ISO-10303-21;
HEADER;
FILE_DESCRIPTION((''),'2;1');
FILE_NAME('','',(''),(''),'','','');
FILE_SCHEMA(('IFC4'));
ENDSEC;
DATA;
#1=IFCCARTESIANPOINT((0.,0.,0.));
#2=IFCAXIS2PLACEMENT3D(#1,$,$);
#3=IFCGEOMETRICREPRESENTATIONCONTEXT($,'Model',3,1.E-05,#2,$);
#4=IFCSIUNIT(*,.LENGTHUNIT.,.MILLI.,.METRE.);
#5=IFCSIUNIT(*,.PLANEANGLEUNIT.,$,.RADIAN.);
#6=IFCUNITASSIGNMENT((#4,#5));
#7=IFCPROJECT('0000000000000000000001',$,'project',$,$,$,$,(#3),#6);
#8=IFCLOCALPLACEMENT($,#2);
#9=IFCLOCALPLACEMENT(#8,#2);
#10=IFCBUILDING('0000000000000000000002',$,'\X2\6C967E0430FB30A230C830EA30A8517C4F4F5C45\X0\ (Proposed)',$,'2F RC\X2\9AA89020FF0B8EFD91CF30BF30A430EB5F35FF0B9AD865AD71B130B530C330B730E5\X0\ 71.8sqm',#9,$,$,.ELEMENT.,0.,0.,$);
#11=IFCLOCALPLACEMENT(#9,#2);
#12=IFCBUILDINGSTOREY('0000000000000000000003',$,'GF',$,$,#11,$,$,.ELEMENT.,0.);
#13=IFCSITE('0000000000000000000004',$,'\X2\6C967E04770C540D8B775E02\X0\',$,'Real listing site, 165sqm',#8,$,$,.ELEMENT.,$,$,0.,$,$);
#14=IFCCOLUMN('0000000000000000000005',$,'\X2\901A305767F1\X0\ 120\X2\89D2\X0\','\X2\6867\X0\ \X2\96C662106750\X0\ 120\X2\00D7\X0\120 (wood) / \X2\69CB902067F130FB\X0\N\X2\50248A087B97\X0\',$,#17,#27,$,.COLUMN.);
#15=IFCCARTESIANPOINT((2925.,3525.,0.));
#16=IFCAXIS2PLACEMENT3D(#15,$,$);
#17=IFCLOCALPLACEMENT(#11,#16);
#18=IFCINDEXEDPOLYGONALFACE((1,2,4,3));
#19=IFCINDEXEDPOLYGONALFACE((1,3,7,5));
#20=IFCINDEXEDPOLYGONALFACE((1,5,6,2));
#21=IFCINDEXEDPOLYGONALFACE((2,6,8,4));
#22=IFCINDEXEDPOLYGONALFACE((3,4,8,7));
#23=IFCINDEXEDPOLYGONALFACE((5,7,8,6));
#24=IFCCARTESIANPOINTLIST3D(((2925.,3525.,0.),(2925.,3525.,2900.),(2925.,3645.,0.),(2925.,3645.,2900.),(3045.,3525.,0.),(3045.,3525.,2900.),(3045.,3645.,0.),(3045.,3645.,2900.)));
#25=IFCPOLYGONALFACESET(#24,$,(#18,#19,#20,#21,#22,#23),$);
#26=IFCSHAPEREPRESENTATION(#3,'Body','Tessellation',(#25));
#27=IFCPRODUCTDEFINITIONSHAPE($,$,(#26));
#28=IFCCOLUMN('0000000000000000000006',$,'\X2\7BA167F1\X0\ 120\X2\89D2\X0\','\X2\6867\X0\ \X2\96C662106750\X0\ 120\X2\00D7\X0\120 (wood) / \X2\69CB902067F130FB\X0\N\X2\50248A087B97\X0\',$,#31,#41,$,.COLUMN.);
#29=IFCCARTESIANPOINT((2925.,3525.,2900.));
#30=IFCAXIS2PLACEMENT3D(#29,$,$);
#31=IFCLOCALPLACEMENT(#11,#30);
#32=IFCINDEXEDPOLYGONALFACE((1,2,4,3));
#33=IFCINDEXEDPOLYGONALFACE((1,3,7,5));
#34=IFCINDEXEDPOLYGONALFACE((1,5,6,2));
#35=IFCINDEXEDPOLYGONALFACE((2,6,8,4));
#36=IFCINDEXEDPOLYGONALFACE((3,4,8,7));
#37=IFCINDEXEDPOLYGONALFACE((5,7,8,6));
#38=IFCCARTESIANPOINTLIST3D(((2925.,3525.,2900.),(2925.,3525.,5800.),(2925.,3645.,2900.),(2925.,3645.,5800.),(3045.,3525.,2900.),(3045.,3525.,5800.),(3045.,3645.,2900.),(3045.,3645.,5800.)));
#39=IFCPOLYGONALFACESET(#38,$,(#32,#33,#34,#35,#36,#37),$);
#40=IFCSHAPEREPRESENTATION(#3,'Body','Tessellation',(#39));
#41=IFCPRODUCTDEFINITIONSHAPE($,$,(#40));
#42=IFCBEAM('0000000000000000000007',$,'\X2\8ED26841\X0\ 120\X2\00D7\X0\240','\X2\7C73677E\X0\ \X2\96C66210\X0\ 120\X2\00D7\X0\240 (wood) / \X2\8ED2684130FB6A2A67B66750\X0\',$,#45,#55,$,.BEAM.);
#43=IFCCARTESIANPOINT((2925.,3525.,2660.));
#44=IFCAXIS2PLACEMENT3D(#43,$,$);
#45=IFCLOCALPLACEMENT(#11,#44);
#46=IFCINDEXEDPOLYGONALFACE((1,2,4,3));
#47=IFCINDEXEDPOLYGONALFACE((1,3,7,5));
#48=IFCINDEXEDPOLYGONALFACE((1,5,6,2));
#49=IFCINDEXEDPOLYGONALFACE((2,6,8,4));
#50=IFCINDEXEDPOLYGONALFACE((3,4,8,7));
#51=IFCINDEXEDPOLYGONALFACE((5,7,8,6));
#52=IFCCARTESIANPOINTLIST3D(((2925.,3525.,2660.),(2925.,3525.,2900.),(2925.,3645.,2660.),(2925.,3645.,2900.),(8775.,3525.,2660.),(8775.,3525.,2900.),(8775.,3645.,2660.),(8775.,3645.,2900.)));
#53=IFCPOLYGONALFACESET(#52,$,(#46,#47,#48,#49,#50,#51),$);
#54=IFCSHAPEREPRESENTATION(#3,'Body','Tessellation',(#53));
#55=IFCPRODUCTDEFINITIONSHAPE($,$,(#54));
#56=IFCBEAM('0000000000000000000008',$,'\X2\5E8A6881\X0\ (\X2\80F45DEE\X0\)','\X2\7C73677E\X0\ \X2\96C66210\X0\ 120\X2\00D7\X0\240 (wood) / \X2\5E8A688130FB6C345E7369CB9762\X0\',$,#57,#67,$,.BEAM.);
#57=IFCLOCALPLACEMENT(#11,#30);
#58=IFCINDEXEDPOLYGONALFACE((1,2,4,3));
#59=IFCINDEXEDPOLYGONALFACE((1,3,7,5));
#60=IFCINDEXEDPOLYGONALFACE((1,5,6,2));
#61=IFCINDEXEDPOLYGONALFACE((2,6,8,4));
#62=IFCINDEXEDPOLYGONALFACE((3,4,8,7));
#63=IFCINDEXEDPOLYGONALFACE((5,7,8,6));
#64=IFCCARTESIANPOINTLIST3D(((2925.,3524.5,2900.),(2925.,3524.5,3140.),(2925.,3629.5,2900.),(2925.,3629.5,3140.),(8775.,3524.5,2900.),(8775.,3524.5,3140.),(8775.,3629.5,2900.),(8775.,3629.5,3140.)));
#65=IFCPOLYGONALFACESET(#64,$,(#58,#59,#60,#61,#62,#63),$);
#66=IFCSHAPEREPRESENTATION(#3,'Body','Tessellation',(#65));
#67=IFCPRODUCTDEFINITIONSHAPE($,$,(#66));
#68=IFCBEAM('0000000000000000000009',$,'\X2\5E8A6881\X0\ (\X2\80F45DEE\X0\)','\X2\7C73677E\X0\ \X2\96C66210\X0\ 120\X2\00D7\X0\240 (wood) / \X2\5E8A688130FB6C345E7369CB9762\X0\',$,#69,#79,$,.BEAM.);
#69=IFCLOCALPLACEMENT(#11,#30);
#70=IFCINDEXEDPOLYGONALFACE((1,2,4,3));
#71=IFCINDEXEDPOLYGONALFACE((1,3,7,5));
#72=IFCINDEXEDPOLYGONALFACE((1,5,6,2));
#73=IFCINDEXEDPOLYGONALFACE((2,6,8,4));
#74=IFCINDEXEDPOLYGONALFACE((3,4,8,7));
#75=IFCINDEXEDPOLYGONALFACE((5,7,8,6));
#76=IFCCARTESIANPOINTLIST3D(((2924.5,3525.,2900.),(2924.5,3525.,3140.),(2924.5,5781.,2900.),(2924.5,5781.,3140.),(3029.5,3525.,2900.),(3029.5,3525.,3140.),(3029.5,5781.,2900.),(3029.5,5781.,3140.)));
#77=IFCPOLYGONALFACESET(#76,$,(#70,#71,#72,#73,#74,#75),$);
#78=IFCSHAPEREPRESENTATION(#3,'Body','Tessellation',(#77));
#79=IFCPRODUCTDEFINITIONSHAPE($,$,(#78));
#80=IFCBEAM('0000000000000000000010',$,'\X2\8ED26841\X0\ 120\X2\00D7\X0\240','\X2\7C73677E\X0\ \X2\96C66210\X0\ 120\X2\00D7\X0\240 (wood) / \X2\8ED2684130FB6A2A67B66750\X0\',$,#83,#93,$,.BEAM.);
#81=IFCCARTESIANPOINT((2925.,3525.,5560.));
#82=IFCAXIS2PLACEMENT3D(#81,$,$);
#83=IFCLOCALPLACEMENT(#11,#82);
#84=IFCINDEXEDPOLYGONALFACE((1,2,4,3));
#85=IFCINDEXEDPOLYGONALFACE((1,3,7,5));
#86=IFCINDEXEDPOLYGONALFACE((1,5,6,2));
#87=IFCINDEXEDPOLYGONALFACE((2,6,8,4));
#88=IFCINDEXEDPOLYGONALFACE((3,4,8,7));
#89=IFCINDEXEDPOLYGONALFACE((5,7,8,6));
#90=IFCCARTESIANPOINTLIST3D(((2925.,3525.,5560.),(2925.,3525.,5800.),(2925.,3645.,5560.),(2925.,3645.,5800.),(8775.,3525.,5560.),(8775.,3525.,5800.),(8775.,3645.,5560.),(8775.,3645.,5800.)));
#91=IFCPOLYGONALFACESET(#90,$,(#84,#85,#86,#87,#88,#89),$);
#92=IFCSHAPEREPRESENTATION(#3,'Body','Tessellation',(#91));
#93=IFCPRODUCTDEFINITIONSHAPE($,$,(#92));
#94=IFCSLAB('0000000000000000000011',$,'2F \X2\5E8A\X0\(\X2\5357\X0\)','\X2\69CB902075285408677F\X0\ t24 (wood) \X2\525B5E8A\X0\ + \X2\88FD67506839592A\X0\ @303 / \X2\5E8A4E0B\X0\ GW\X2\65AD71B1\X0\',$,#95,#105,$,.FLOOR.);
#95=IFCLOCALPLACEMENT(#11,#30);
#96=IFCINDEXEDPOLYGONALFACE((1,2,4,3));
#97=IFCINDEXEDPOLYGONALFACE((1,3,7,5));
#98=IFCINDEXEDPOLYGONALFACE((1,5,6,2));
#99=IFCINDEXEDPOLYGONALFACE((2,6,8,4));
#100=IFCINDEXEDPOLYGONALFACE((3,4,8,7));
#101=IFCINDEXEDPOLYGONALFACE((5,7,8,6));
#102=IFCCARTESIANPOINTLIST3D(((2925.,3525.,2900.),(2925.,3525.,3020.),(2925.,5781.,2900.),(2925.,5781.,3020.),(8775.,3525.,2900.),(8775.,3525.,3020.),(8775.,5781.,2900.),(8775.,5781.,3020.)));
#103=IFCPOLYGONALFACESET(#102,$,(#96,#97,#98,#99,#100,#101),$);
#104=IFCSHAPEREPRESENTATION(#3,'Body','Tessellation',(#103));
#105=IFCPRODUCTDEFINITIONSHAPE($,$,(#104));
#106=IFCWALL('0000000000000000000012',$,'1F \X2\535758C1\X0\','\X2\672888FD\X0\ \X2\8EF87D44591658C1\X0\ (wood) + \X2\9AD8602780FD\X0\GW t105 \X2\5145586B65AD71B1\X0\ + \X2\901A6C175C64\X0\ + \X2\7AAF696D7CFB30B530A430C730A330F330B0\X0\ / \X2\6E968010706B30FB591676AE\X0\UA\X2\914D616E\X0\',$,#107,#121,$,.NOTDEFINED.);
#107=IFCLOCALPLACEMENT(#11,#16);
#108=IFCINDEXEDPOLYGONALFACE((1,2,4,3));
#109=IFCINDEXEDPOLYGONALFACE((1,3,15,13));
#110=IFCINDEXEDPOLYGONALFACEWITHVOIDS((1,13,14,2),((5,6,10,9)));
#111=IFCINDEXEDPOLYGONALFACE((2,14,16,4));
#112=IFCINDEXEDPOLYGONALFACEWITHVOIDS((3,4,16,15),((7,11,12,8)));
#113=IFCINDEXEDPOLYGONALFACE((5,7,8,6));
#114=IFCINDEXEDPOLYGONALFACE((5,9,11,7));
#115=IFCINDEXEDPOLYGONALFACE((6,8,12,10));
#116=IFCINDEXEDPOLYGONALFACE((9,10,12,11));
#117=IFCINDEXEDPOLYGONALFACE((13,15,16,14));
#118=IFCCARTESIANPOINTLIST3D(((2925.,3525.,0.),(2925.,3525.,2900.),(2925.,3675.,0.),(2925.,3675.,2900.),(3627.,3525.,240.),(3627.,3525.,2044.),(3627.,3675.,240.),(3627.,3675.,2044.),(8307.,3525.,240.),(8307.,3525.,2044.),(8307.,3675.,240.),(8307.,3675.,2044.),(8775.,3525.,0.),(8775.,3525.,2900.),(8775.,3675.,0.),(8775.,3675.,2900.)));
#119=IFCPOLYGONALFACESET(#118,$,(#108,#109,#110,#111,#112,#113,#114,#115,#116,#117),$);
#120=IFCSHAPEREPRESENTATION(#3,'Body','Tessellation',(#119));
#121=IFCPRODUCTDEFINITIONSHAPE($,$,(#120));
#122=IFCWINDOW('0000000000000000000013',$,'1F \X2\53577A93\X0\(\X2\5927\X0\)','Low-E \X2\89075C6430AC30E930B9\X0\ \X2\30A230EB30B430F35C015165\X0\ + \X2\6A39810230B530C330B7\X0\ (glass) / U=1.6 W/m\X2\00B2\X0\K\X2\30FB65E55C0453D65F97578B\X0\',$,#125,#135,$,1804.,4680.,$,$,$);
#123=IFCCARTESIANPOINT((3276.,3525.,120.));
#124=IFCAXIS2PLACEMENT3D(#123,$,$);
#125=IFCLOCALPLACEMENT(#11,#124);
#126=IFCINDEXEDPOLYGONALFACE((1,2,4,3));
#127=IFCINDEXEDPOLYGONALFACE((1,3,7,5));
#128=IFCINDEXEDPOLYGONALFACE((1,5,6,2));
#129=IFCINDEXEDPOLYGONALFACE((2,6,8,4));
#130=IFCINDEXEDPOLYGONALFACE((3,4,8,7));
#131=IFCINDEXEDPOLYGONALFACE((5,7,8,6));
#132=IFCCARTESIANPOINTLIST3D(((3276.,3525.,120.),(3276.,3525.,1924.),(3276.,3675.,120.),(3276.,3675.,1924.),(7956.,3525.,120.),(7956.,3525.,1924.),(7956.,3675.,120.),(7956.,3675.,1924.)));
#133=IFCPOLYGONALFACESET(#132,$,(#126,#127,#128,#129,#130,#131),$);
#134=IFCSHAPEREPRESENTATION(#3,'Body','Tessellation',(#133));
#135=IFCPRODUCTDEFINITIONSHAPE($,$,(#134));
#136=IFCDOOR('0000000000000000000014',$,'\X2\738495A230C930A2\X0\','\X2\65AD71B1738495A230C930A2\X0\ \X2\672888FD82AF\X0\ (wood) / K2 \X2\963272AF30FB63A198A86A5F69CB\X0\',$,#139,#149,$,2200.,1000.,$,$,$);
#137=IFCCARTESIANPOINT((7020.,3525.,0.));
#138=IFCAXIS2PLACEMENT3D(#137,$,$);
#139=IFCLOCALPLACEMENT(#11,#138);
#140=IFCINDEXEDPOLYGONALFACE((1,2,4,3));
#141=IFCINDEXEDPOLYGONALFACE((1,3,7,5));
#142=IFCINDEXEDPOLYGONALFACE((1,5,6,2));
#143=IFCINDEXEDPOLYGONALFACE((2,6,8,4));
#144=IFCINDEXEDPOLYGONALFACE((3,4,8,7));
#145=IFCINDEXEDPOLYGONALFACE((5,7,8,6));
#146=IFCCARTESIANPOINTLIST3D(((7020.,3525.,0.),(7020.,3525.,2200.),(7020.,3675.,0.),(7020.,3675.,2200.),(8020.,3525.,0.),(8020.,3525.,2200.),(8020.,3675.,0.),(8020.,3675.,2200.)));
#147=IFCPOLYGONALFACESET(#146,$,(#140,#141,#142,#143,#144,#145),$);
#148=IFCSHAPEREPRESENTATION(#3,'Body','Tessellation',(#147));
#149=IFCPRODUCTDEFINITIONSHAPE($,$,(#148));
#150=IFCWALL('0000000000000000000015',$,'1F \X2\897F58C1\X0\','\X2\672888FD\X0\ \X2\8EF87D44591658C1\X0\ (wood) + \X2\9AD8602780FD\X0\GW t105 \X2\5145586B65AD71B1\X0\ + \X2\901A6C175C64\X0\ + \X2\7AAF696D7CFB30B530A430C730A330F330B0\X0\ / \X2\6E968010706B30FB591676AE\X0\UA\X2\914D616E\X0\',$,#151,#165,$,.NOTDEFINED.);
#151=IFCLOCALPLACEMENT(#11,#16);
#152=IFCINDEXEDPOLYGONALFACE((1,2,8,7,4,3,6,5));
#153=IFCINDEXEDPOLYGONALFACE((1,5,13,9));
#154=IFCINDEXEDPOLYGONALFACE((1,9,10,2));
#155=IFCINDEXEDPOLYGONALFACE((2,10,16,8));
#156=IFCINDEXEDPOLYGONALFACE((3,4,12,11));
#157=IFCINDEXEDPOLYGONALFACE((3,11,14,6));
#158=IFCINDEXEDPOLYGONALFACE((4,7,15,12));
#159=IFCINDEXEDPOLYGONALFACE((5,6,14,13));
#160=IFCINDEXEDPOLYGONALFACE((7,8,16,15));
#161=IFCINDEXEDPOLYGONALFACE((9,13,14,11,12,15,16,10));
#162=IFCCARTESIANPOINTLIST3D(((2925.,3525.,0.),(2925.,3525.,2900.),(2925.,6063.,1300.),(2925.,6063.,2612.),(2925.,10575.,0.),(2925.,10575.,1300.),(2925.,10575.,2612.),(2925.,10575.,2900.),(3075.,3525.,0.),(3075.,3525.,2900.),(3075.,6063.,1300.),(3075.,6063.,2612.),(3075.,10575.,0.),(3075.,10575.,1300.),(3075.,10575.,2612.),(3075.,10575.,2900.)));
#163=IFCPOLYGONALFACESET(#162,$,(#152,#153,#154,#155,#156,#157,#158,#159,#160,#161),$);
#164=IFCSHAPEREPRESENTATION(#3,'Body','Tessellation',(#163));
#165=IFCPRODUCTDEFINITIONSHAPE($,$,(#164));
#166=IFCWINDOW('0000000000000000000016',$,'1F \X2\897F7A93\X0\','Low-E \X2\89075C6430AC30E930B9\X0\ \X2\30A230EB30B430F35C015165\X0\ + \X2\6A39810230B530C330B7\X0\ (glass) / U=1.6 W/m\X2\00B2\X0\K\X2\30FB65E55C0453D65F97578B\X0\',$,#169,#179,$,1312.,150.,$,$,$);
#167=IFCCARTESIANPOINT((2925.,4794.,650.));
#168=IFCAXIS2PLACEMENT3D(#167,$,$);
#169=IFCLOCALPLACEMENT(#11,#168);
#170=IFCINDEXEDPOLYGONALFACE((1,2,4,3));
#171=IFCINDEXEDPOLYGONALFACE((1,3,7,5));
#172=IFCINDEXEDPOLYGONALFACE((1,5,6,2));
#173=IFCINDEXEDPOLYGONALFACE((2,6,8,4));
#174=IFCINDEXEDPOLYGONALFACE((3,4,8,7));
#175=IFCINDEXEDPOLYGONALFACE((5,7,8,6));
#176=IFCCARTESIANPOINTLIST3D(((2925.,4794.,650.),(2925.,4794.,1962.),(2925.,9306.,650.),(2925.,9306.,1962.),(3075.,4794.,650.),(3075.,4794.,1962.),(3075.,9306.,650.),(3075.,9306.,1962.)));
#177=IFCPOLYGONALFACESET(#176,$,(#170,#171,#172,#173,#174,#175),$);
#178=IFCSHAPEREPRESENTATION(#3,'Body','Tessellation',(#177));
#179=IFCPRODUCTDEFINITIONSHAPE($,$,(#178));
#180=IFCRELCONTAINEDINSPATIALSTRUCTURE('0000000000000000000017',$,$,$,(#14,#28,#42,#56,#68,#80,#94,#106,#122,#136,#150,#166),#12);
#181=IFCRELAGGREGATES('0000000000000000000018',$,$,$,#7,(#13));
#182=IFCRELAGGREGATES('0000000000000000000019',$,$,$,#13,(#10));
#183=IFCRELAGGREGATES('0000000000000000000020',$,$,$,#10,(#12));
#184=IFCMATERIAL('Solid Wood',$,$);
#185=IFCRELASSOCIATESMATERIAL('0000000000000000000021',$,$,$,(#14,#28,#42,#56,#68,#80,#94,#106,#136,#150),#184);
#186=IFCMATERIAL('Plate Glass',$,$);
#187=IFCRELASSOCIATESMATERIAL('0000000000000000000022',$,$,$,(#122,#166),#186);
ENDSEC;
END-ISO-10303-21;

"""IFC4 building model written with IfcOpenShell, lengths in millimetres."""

from ifc_helpers import new_model, si_unit, frame, frame_2d, origin, place, context, project, spatial, rectangle, extrude, material, element, fill, save


model = new_model("IFC4")

# Units and contexts
model_context = context("Model", 3, precision=1e-05, world=origin())
ifc_project = project(units=[si_unit("LENGTHUNIT", "METRE", prefix="MILLI"), si_unit("PLANEANGLEUNIT", "RADIAN")], contexts=[model_context])

# Site, building, storey
site_placement = place(None, origin())
site = spatial("IfcSite", under=ifc_project, at=site_placement, Name="沖縄県名護市", ObjectType="Real listing site, 165sqm", CompositionType="ELEMENT", RefElevation=0.0)
building_placement = place(site_placement, origin())
building = spatial("IfcBuilding", under=site, at=building_placement, Name="沖縄・アトリエ兼住居 (Proposed)", ObjectType="2F RC骨造＋軽量タイル張＋高断熱サッシュ 71.8sqm", CompositionType="ELEMENT", ElevationOfRefHeight=0.0, ElevationOfTerrain=0.0)
storey_placement = place(building_placement, origin())
storey = spatial("IfcBuildingStorey", under=building, at=storey_placement, Name="GF", CompositionType="ELEMENT", Elevation=0.0)

# Columns
ifc_material_1 = material(Name="Solid Wood")
column_1_placement = place(storey_placement, frame((2925.0, 3525.0, 0.0)))
element("IfcColumn", 1, at=column_1_placement, inside=storey, material=ifc_material_1, Name="通し柱 120角", Description="桧 集成材 120×120 (wood) / 構造柱・N値計算", PredefinedType="COLUMN", context=model_context, shape_type="SweptSolid", body=[
    extrude(rectangle(XDim=120.0, YDim=120.0, at=frame_2d((60.0, 60.0))), frame((2925.0, 3525.0, 0.0)), (0.0, 0.0, 1.0), 2900.0),
])
column_2_placement = place(storey_placement, frame((2925.0, 3525.0, 2900.0)))
element("IfcColumn", 2, at=column_2_placement, inside=storey, material=ifc_material_1, Name="管柱 120角", Description="桧 集成材 120×120 (wood) / 構造柱・N値計算", PredefinedType="COLUMN", context=model_context, shape_type="SweptSolid", body=[
    extrude(rectangle(XDim=120.0, YDim=120.0, at=frame_2d((60.0, 60.0))), frame((2925.0, 3525.0, 2900.0)), (0.0, 0.0, 1.0), 2900.0),
])

# Beams
beam_1_placement = place(storey_placement, frame((2925.0, 3525.0, 2660.0)))
element("IfcBeam", 3, at=beam_1_placement, inside=storey, material=ifc_material_1, Name="軒桁 120×240", Description="米松 集成 120×240 (wood) / 軒桁・横架材", PredefinedType="BEAM", context=model_context, shape_type="SweptSolid", body=[
    extrude(rectangle(XDim=5850.0, YDim=120.0, at=frame_2d((2925.0, 60.0))), frame((2925.0, 3525.0, 2660.0)), (0.0, 0.0, 1.0), 240.0),
])
beam_2_placement = place(storey_placement, frame((2925.0, 3525.0, 2900.0)))
element("IfcBeam", 4, at=beam_2_placement, inside=storey, material=ifc_material_1, Name="床梁 (胴差)", Description="米松 集成 120×240 (wood) / 床梁・水平構面", PredefinedType="BEAM", context=model_context, shape_type="SweptSolid", body=[
    extrude(rectangle(XDim=5850.0, YDim=105.0, at=frame_2d((2925.0, 52.0))), frame((2925.0, 3525.0, 2900.0)), (0.0, 0.0, 1.0), 240.0),
])
beam_3_placement = place(storey_placement, frame((2925.0, 3525.0, 2900.0)))
element("IfcBeam", 5, at=beam_3_placement, inside=storey, material=ifc_material_1, Name="床梁 (胴差)", Description="米松 集成 120×240 (wood) / 床梁・水平構面", PredefinedType="BEAM", context=model_context, shape_type="SweptSolid", body=[
    extrude(rectangle(XDim=105.0, YDim=2256.0, at=frame_2d((52.0, 1128.0))), frame((2925.0, 3525.0, 2900.0)), (0.0, 0.0, 1.0), 240.0),
])
beam_4_placement = place(storey_placement, frame((2925.0, 3525.0, 5560.0)))
element("IfcBeam", 6, at=beam_4_placement, inside=storey, material=ifc_material_1, Name="軒桁 120×240", Description="米松 集成 120×240 (wood) / 軒桁・横架材", PredefinedType="BEAM", context=model_context, shape_type="SweptSolid", body=[
    extrude(rectangle(XDim=5850.0, YDim=120.0, at=frame_2d((2925.0, 60.0))), frame((2925.0, 3525.0, 5560.0)), (0.0, 0.0, 1.0), 240.0),
])

# Slab
slab_1_placement = place(storey_placement, frame((2925.0, 3525.0, 2900.0)))
element("IfcSlab", 7, at=slab_1_placement, inside=storey, material=ifc_material_1, Name="2F 床(南)", Description="構造用合板 t24 (wood) 剛床 + 製材根太 @303 / 床下 GW断熱", PredefinedType="FLOOR", context=model_context, shape_type="SweptSolid", body=[
    extrude(rectangle(XDim=5850.0, YDim=2256.0, at=frame_2d((2925.0, 1128.0))), frame((2925.0, 3525.0, 2900.0)), (0.0, 0.0, 1.0), 120.0),
])

# Wall, openings, window, door
wall_1_placement = place(storey_placement, frame((2925.0, 3525.0, 0.0)))
wall_1 = element("IfcWall", 8, at=wall_1_placement, inside=storey, material=ifc_material_1, Name="1F 南壁", Description="木製 軸組外壁 (wood) + 高性能GW t105 充填断熱 + 通気層 + 窯業系サイディング / 準耐火・外皮UA配慮", PredefinedType="NOTDEFINED", context=model_context, shape_type="SweptSolid", body=[
    extrude(rectangle(XDim=5850.0, YDim=150.0, at=frame_2d((2925.0, 75.0))), frame((2925.0, 3525.0, 0.0)), (0.0, 0.0, 1.0), 2900.0),
])
opening_1_placement = place(storey_placement, frame((3276.0, 3525.0, 120.0)))
opening_1 = element("IfcOpeningElement", 9, at=opening_1_placement, cuts=wall_1, PredefinedType="NOTDEFINED", context=model_context, shape_type="SweptSolid", body=[
    extrude(rectangle(XDim=4680.0, YDim=150.0, at=frame_2d((2340.0, 75.0))), frame((3276.0, 3525.0, 120.0)), (0.0, 0.0, 1.0), 1804.0),
])
opening_2_placement = place(storey_placement, frame((7020.0, 3525.0, 0.0)))
opening_2 = element("IfcOpeningElement", 10, at=opening_2_placement, cuts=wall_1, PredefinedType="NOTDEFINED", context=model_context, shape_type="SweptSolid", body=[
    extrude(rectangle(XDim=1000.0, YDim=150.0, at=frame_2d((500.0, 75.0))), frame((7020.0, 3525.0, 0.0)), (0.0, 0.0, 1.0), 2200.0),
])
ifc_material_2 = material(Name="Plate Glass")
window_1_placement = place(storey_placement, frame((3276.0, 3525.0, 120.0)))
window_1 = element("IfcWindow", 11, at=window_1_placement, inside=storey, material=ifc_material_2, Name="1F 南窓(大)", Description="Low-E 複層ガラス アルゴン封入 + 樹脂サッシ (glass) / U=1.6 W/m²K・日射取得型", OverallHeight=1804.0, OverallWidth=4680.0, context=model_context, shape_type="SweptSolid", body=[
    extrude(rectangle(XDim=4680.0, YDim=150.0, at=frame_2d((2340.0, 75.0))), frame((3276.0, 3525.0, 120.0)), (0.0, 0.0, 1.0), 1804.0),
])
fill(opening_1, window_1)
door_placement = place(storey_placement, frame((7020.0, 3525.0, 0.0)))
door = element("IfcDoor", 12, at=door_placement, inside=storey, material=ifc_material_1, Name="玄関ドア", Description="断熱玄関ドア 木製芯 (wood) / K2 防犯・採風機構", OverallHeight=2200.0, OverallWidth=1000.0, context=model_context, shape_type="SweptSolid", body=[
    extrude(rectangle(XDim=1000.0, YDim=150.0, at=frame_2d((500.0, 75.0))), frame((7020.0, 3525.0, 0.0)), (0.0, 0.0, 1.0), 2200.0),
])
fill(opening_2, door)

# Wall, opening, window
wall_2_placement = place(storey_placement, frame((2925.0, 3525.0, 0.0)))
wall_2 = element("IfcWall", 13, at=wall_2_placement, inside=storey, material=ifc_material_1, Name="1F 西壁", Description="木製 軸組外壁 (wood) + 高性能GW t105 充填断熱 + 通気層 + 窯業系サイディング / 準耐火・外皮UA配慮", PredefinedType="NOTDEFINED", context=model_context, shape_type="SweptSolid", body=[
    extrude(rectangle(XDim=150.0, YDim=7050.0, at=frame_2d((75.0, 3525.0))), frame((2925.0, 3525.0, 0.0)), (0.0, 0.0, 1.0), 2900.0),
])
opening_3_placement = place(storey_placement, frame((2925.0, 4794.0, 650.0)))
opening_3 = element("IfcOpeningElement", 14, at=opening_3_placement, cuts=wall_2, PredefinedType="NOTDEFINED", context=model_context, shape_type="SweptSolid", body=[
    extrude(rectangle(XDim=150.0, YDim=4512.0, at=frame_2d((75.0, 2256.0))), frame((2925.0, 4794.0, 650.0)), (0.0, 0.0, 1.0), 1312.0),
])
window_2_placement = place(storey_placement, frame((2925.0, 4794.0, 650.0)))
window_2 = element("IfcWindow", 15, at=window_2_placement, inside=storey, material=ifc_material_2, Name="1F 西窓", Description="Low-E 複層ガラス アルゴン封入 + 樹脂サッシ (glass) / U=1.6 W/m²K・日射取得型", OverallHeight=1312.0, OverallWidth=150.0, context=model_context, shape_type="SweptSolid", body=[
    extrude(rectangle(XDim=150.0, YDim=4512.0, at=frame_2d((75.0, 2256.0))), frame((2925.0, 4794.0, 650.0)), (0.0, 0.0, 1.0), 1312.0),
])
fill(opening_3, window_2)

save(model, "model.ifc")
